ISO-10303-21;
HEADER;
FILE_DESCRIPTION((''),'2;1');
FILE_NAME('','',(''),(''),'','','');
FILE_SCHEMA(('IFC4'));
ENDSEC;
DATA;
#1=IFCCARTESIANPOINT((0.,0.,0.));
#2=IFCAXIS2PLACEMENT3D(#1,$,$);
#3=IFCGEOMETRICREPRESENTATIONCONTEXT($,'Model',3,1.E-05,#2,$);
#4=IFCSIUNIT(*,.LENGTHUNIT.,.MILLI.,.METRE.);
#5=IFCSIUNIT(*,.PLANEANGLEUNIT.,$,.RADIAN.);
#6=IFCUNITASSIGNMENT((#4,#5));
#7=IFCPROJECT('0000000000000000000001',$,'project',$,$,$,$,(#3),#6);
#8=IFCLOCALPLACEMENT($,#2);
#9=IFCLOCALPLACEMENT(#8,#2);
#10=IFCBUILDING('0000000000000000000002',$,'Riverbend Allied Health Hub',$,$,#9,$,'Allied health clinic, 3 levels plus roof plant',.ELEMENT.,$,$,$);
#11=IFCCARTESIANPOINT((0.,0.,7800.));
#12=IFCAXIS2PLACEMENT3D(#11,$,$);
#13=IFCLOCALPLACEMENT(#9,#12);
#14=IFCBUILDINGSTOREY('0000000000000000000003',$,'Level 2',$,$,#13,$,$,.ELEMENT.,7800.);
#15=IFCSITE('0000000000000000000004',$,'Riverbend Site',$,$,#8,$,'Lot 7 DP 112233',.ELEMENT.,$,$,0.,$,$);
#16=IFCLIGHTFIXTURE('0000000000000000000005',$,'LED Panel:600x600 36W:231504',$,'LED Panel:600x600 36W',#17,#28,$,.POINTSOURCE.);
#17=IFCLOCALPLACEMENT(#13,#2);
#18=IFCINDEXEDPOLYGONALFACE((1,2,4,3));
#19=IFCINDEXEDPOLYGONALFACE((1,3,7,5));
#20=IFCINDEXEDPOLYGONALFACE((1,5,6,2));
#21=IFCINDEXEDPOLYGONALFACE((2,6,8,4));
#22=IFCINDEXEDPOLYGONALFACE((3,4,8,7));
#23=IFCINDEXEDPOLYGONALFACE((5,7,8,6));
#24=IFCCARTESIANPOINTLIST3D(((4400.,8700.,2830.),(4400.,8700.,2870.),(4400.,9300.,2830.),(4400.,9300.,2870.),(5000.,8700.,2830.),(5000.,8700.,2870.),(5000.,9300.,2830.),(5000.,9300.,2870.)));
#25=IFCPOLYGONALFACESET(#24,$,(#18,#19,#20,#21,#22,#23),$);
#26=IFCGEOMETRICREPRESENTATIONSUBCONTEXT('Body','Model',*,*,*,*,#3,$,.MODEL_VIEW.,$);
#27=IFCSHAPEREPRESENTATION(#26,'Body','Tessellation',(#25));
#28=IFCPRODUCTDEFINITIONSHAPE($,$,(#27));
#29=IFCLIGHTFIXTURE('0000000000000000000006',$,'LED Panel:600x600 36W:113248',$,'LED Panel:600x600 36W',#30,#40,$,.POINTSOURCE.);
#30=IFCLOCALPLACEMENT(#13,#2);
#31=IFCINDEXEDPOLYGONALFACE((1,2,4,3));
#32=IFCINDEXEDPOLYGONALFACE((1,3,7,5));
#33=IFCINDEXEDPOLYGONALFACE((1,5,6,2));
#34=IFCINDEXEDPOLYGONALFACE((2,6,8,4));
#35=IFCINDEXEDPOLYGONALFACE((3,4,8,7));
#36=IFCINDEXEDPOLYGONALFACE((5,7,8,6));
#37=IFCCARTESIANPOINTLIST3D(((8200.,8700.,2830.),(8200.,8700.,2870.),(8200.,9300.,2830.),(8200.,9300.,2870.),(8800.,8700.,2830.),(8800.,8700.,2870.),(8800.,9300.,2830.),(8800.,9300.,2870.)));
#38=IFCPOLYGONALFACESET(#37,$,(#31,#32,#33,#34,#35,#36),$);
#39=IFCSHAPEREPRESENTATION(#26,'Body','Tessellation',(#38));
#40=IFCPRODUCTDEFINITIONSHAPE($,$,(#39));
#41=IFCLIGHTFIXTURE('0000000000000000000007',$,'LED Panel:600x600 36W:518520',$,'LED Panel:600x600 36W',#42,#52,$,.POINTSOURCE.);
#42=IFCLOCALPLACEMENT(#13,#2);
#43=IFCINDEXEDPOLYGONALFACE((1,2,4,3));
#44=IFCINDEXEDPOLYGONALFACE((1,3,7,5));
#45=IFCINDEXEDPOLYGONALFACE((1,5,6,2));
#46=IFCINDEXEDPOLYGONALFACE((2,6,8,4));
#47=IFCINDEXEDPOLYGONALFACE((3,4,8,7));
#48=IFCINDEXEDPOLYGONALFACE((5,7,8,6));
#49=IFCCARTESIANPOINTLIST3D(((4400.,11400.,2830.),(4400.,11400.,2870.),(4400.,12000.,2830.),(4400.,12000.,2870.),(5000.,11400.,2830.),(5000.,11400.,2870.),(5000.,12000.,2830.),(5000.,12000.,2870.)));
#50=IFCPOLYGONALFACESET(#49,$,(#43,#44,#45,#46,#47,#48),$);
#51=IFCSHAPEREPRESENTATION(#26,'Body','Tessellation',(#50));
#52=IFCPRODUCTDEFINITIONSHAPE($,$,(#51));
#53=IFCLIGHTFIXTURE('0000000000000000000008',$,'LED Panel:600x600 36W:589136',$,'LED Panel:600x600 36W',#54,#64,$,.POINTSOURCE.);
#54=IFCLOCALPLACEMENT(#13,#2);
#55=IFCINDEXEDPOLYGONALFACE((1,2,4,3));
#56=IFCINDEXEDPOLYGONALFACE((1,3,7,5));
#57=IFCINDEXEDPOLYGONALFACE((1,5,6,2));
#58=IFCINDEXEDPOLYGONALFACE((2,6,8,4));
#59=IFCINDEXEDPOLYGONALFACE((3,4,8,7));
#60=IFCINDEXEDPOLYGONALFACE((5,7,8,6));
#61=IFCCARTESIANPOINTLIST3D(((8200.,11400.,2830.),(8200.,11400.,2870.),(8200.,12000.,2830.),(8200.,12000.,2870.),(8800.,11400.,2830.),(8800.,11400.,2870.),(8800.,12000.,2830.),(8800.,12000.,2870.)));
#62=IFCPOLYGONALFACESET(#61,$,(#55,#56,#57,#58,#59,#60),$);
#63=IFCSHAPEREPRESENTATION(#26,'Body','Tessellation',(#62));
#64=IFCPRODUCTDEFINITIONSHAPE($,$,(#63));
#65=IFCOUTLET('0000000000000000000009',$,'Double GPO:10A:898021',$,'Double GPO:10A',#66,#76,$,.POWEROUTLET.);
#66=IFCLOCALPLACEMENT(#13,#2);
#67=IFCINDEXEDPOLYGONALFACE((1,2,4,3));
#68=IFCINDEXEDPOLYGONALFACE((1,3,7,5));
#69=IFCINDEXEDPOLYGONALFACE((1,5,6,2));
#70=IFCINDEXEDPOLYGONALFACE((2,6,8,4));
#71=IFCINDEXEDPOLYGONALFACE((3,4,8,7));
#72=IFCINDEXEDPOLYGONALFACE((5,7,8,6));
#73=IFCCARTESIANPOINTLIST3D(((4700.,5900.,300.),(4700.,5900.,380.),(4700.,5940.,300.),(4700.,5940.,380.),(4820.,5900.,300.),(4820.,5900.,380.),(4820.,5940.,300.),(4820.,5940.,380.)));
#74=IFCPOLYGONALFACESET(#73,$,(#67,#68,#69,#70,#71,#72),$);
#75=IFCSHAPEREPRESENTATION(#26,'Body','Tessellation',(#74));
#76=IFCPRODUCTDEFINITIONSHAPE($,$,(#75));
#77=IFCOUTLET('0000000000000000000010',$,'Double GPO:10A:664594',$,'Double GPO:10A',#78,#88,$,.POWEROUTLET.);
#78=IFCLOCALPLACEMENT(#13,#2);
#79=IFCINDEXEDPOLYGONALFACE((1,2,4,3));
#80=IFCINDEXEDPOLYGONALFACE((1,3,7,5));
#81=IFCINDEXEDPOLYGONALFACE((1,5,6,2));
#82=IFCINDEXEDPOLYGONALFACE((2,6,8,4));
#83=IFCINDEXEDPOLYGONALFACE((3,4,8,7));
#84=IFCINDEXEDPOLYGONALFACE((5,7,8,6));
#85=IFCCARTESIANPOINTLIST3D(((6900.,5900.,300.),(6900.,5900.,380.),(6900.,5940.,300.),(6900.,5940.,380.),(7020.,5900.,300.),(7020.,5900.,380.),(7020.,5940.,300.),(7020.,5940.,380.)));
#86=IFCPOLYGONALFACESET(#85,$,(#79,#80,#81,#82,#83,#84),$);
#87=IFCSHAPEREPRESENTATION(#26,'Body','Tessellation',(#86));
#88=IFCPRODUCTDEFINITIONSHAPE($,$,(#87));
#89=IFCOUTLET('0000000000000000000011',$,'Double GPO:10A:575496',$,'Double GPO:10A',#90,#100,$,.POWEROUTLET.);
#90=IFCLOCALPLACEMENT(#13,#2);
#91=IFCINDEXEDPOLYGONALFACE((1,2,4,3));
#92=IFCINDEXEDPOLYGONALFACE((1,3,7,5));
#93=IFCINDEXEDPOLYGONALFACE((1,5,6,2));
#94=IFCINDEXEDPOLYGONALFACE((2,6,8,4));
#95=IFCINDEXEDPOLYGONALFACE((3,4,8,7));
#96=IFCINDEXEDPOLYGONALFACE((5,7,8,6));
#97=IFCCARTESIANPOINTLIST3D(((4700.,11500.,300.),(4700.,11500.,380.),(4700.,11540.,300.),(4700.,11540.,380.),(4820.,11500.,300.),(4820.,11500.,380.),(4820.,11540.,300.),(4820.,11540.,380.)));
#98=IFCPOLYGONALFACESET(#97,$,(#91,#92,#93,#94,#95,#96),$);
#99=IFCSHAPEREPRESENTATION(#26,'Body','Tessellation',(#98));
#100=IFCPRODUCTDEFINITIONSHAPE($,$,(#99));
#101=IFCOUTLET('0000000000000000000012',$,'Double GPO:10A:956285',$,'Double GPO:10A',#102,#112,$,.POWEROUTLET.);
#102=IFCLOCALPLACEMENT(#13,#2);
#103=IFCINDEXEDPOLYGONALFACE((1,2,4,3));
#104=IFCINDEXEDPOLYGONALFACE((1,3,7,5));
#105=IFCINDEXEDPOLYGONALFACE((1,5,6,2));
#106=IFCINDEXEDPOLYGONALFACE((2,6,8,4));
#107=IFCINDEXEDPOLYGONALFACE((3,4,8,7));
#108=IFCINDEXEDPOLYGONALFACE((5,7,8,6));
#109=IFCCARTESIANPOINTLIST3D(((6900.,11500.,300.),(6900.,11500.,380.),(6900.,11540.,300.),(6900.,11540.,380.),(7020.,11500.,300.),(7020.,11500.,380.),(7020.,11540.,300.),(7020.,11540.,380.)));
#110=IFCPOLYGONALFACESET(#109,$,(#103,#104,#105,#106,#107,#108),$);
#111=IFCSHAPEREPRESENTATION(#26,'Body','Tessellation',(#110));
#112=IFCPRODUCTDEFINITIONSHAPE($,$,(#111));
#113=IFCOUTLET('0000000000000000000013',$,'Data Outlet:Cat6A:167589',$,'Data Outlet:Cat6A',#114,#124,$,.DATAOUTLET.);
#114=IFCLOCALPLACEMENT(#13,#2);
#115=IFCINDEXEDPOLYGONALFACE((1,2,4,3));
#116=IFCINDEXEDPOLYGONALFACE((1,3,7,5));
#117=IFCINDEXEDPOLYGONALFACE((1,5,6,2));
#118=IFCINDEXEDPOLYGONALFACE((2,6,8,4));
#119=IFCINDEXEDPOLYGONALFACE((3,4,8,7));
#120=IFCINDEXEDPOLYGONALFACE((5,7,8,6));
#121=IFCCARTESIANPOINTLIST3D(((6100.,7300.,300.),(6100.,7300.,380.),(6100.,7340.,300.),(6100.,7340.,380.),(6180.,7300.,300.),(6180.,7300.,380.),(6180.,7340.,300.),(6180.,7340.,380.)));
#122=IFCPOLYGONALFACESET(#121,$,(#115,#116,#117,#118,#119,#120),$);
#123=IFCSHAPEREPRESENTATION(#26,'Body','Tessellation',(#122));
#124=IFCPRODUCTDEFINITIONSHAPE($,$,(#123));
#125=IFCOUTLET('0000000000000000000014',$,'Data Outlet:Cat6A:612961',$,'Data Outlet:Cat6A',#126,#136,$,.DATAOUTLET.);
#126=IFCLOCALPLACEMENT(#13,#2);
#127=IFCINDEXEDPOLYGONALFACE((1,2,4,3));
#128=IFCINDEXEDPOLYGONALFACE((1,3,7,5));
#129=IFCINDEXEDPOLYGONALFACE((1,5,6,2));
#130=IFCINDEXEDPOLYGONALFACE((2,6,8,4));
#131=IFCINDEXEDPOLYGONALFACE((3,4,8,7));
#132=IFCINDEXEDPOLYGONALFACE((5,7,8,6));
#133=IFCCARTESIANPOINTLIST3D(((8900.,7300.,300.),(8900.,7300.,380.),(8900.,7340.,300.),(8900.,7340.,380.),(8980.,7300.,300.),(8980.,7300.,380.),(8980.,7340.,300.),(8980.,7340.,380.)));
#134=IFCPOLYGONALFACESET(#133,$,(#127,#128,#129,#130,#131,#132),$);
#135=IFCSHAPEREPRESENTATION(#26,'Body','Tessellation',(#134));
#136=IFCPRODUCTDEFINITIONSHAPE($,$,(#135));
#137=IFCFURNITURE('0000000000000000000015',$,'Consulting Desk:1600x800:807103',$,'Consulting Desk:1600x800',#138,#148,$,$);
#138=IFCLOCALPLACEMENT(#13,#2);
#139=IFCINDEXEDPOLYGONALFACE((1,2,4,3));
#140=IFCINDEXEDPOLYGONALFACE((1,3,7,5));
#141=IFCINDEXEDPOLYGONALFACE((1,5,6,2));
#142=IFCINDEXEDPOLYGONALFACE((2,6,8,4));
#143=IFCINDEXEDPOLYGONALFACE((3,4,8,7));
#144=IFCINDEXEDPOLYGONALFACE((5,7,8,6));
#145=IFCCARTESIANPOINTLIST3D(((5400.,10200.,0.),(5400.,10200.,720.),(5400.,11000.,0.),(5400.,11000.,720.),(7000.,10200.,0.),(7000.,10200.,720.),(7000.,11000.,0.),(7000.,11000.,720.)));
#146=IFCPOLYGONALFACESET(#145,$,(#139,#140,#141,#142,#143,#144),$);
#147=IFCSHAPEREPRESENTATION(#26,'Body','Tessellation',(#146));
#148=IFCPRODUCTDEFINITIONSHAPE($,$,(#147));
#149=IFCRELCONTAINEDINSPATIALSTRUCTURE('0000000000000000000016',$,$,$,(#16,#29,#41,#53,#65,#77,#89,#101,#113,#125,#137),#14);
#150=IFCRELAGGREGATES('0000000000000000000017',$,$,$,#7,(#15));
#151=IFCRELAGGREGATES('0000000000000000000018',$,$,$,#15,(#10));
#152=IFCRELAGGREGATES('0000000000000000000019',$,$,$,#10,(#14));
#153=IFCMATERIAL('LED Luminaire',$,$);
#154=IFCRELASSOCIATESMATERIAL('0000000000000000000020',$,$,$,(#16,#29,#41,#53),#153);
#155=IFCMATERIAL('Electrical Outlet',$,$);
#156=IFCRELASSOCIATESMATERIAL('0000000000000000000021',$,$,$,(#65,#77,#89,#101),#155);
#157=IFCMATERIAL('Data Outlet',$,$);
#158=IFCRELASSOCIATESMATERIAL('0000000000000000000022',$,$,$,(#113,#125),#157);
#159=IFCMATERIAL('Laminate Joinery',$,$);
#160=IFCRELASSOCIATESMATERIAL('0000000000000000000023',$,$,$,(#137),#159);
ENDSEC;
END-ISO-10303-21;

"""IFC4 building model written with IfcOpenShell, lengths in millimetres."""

from ifc_helpers import new_model, si_unit, frame, frame_2d, origin, place, context, subcontext, project, spatial, rectangle, extrude, material, element, save


model = new_model("IFC4")

# Units and contexts
model_context = context("Model", 3, precision=1e-05, world=origin())
body_context = subcontext(model_context, "Body", "Model", "MODEL_VIEW")
ifc_project = project(units=[si_unit("LENGTHUNIT", "METRE", prefix="MILLI"), si_unit("PLANEANGLEUNIT", "RADIAN")], contexts=[model_context])

# Site, building, storey
site_placement = place(None, origin())
site = spatial("IfcSite", under=ifc_project, at=site_placement, Name="Riverbend Site", LongName="Lot 7 DP 112233", CompositionType="ELEMENT", RefElevation=0.0)
building_placement = place(site_placement, origin())
building = spatial("IfcBuilding", under=site, at=building_placement, Name="Riverbend Allied Health Hub", LongName="Allied health clinic, 3 levels plus roof plant", CompositionType="ELEMENT")
storey_placement = place(building_placement, frame((0.0, 0.0, 7800.0)))
storey = spatial("IfcBuildingStorey", under=building, at=storey_placement, Name="Level 2", CompositionType="ELEMENT", Elevation=7800.0)

# Light fixtures
ifc_material_1 = material(Name="LED Luminaire")
for number, where, name in (
    (1, (4400.0, 8700.0, 2830.0), "LED Panel:600x600 36W:231504"),
    (2, (8200.0, 8700.0, 2830.0), "LED Panel:600x600 36W:113248"),
    (3, (4400.0, 11400.0, 2830.0), "LED Panel:600x600 36W:518520"),
    (4, (8200.0, 11400.0, 2830.0), "LED Panel:600x600 36W:589136"),
):
    element("IfcLightFixture", number, at=place(storey_placement, frame(where)), inside=storey, material=ifc_material_1, Name=name, ObjectType="LED Panel:600x600 36W", PredefinedType="POINTSOURCE", context=body_context, shape_type="SweptSolid", body=[
        extrude(rectangle(XDim=600.0, YDim=600.0, at=frame_2d((300.0, 300.0))), origin(), (0.0, 0.0, 1.0), 40.0),
    ])

# Outlets
ifc_material_2 = material(Name="Electrical Outlet")
for number, where, name in (
    (5, (4700.0, 5900.0, 300.0), "Double GPO:10A:898021"),
    (6, (6900.0, 5900.0, 300.0), "Double GPO:10A:664594"),
    (7, (4700.0, 11500.0, 300.0), "Double GPO:10A:575496"),
    (8, (6900.0, 11500.0, 300.0), "Double GPO:10A:956285"),
):
    element("IfcOutlet", number, at=place(storey_placement, frame(where)), inside=storey, material=ifc_material_2, Name=name, ObjectType="Double GPO:10A", PredefinedType="POWEROUTLET", context=body_context, shape_type="SweptSolid", body=[
        extrude(rectangle(XDim=120.0, YDim=40.0, at=frame_2d((60.0, 20.0))), origin(), (0.0, 0.0, 1.0), 80.0),
    ])
ifc_material_3 = material(Name="Data Outlet")
for number, where, name in (
    (9, (6100.0, 7300.0, 300.0), "Data Outlet:Cat6A:167589"),
    (10, (8900.0, 7300.0, 300.0), "Data Outlet:Cat6A:612961"),
):
    element("IfcOutlet", number, at=place(storey_placement, frame(where)), inside=storey, material=ifc_material_3, Name=name, ObjectType="Data Outlet:Cat6A", PredefinedType="DATAOUTLET", context=body_context, shape_type="SweptSolid", body=[
        extrude(rectangle(XDim=80.0, YDim=40.0, at=frame_2d((40.0, 20.0))), origin(), (0.0, 0.0, 1.0), 80.0),
    ])

# Furniture
ifc_material_4 = material(Name="Laminate Joinery")
furniture_placement = place(storey_placement, frame((5400.0, 10200.0, 0.0)))
element("IfcFurniture", 11, at=furniture_placement, inside=storey, material=ifc_material_4, Name="Consulting Desk:1600x800:807103", ObjectType="Consulting Desk:1600x800", context=body_context, shape_type="SweptSolid", body=[
    extrude(rectangle(XDim=1600.0, YDim=800.0, at=frame_2d((800.0, 400.0))), origin(), (0.0, 0.0, 1.0), 720.0),
])

save(model, "model.ifc")
